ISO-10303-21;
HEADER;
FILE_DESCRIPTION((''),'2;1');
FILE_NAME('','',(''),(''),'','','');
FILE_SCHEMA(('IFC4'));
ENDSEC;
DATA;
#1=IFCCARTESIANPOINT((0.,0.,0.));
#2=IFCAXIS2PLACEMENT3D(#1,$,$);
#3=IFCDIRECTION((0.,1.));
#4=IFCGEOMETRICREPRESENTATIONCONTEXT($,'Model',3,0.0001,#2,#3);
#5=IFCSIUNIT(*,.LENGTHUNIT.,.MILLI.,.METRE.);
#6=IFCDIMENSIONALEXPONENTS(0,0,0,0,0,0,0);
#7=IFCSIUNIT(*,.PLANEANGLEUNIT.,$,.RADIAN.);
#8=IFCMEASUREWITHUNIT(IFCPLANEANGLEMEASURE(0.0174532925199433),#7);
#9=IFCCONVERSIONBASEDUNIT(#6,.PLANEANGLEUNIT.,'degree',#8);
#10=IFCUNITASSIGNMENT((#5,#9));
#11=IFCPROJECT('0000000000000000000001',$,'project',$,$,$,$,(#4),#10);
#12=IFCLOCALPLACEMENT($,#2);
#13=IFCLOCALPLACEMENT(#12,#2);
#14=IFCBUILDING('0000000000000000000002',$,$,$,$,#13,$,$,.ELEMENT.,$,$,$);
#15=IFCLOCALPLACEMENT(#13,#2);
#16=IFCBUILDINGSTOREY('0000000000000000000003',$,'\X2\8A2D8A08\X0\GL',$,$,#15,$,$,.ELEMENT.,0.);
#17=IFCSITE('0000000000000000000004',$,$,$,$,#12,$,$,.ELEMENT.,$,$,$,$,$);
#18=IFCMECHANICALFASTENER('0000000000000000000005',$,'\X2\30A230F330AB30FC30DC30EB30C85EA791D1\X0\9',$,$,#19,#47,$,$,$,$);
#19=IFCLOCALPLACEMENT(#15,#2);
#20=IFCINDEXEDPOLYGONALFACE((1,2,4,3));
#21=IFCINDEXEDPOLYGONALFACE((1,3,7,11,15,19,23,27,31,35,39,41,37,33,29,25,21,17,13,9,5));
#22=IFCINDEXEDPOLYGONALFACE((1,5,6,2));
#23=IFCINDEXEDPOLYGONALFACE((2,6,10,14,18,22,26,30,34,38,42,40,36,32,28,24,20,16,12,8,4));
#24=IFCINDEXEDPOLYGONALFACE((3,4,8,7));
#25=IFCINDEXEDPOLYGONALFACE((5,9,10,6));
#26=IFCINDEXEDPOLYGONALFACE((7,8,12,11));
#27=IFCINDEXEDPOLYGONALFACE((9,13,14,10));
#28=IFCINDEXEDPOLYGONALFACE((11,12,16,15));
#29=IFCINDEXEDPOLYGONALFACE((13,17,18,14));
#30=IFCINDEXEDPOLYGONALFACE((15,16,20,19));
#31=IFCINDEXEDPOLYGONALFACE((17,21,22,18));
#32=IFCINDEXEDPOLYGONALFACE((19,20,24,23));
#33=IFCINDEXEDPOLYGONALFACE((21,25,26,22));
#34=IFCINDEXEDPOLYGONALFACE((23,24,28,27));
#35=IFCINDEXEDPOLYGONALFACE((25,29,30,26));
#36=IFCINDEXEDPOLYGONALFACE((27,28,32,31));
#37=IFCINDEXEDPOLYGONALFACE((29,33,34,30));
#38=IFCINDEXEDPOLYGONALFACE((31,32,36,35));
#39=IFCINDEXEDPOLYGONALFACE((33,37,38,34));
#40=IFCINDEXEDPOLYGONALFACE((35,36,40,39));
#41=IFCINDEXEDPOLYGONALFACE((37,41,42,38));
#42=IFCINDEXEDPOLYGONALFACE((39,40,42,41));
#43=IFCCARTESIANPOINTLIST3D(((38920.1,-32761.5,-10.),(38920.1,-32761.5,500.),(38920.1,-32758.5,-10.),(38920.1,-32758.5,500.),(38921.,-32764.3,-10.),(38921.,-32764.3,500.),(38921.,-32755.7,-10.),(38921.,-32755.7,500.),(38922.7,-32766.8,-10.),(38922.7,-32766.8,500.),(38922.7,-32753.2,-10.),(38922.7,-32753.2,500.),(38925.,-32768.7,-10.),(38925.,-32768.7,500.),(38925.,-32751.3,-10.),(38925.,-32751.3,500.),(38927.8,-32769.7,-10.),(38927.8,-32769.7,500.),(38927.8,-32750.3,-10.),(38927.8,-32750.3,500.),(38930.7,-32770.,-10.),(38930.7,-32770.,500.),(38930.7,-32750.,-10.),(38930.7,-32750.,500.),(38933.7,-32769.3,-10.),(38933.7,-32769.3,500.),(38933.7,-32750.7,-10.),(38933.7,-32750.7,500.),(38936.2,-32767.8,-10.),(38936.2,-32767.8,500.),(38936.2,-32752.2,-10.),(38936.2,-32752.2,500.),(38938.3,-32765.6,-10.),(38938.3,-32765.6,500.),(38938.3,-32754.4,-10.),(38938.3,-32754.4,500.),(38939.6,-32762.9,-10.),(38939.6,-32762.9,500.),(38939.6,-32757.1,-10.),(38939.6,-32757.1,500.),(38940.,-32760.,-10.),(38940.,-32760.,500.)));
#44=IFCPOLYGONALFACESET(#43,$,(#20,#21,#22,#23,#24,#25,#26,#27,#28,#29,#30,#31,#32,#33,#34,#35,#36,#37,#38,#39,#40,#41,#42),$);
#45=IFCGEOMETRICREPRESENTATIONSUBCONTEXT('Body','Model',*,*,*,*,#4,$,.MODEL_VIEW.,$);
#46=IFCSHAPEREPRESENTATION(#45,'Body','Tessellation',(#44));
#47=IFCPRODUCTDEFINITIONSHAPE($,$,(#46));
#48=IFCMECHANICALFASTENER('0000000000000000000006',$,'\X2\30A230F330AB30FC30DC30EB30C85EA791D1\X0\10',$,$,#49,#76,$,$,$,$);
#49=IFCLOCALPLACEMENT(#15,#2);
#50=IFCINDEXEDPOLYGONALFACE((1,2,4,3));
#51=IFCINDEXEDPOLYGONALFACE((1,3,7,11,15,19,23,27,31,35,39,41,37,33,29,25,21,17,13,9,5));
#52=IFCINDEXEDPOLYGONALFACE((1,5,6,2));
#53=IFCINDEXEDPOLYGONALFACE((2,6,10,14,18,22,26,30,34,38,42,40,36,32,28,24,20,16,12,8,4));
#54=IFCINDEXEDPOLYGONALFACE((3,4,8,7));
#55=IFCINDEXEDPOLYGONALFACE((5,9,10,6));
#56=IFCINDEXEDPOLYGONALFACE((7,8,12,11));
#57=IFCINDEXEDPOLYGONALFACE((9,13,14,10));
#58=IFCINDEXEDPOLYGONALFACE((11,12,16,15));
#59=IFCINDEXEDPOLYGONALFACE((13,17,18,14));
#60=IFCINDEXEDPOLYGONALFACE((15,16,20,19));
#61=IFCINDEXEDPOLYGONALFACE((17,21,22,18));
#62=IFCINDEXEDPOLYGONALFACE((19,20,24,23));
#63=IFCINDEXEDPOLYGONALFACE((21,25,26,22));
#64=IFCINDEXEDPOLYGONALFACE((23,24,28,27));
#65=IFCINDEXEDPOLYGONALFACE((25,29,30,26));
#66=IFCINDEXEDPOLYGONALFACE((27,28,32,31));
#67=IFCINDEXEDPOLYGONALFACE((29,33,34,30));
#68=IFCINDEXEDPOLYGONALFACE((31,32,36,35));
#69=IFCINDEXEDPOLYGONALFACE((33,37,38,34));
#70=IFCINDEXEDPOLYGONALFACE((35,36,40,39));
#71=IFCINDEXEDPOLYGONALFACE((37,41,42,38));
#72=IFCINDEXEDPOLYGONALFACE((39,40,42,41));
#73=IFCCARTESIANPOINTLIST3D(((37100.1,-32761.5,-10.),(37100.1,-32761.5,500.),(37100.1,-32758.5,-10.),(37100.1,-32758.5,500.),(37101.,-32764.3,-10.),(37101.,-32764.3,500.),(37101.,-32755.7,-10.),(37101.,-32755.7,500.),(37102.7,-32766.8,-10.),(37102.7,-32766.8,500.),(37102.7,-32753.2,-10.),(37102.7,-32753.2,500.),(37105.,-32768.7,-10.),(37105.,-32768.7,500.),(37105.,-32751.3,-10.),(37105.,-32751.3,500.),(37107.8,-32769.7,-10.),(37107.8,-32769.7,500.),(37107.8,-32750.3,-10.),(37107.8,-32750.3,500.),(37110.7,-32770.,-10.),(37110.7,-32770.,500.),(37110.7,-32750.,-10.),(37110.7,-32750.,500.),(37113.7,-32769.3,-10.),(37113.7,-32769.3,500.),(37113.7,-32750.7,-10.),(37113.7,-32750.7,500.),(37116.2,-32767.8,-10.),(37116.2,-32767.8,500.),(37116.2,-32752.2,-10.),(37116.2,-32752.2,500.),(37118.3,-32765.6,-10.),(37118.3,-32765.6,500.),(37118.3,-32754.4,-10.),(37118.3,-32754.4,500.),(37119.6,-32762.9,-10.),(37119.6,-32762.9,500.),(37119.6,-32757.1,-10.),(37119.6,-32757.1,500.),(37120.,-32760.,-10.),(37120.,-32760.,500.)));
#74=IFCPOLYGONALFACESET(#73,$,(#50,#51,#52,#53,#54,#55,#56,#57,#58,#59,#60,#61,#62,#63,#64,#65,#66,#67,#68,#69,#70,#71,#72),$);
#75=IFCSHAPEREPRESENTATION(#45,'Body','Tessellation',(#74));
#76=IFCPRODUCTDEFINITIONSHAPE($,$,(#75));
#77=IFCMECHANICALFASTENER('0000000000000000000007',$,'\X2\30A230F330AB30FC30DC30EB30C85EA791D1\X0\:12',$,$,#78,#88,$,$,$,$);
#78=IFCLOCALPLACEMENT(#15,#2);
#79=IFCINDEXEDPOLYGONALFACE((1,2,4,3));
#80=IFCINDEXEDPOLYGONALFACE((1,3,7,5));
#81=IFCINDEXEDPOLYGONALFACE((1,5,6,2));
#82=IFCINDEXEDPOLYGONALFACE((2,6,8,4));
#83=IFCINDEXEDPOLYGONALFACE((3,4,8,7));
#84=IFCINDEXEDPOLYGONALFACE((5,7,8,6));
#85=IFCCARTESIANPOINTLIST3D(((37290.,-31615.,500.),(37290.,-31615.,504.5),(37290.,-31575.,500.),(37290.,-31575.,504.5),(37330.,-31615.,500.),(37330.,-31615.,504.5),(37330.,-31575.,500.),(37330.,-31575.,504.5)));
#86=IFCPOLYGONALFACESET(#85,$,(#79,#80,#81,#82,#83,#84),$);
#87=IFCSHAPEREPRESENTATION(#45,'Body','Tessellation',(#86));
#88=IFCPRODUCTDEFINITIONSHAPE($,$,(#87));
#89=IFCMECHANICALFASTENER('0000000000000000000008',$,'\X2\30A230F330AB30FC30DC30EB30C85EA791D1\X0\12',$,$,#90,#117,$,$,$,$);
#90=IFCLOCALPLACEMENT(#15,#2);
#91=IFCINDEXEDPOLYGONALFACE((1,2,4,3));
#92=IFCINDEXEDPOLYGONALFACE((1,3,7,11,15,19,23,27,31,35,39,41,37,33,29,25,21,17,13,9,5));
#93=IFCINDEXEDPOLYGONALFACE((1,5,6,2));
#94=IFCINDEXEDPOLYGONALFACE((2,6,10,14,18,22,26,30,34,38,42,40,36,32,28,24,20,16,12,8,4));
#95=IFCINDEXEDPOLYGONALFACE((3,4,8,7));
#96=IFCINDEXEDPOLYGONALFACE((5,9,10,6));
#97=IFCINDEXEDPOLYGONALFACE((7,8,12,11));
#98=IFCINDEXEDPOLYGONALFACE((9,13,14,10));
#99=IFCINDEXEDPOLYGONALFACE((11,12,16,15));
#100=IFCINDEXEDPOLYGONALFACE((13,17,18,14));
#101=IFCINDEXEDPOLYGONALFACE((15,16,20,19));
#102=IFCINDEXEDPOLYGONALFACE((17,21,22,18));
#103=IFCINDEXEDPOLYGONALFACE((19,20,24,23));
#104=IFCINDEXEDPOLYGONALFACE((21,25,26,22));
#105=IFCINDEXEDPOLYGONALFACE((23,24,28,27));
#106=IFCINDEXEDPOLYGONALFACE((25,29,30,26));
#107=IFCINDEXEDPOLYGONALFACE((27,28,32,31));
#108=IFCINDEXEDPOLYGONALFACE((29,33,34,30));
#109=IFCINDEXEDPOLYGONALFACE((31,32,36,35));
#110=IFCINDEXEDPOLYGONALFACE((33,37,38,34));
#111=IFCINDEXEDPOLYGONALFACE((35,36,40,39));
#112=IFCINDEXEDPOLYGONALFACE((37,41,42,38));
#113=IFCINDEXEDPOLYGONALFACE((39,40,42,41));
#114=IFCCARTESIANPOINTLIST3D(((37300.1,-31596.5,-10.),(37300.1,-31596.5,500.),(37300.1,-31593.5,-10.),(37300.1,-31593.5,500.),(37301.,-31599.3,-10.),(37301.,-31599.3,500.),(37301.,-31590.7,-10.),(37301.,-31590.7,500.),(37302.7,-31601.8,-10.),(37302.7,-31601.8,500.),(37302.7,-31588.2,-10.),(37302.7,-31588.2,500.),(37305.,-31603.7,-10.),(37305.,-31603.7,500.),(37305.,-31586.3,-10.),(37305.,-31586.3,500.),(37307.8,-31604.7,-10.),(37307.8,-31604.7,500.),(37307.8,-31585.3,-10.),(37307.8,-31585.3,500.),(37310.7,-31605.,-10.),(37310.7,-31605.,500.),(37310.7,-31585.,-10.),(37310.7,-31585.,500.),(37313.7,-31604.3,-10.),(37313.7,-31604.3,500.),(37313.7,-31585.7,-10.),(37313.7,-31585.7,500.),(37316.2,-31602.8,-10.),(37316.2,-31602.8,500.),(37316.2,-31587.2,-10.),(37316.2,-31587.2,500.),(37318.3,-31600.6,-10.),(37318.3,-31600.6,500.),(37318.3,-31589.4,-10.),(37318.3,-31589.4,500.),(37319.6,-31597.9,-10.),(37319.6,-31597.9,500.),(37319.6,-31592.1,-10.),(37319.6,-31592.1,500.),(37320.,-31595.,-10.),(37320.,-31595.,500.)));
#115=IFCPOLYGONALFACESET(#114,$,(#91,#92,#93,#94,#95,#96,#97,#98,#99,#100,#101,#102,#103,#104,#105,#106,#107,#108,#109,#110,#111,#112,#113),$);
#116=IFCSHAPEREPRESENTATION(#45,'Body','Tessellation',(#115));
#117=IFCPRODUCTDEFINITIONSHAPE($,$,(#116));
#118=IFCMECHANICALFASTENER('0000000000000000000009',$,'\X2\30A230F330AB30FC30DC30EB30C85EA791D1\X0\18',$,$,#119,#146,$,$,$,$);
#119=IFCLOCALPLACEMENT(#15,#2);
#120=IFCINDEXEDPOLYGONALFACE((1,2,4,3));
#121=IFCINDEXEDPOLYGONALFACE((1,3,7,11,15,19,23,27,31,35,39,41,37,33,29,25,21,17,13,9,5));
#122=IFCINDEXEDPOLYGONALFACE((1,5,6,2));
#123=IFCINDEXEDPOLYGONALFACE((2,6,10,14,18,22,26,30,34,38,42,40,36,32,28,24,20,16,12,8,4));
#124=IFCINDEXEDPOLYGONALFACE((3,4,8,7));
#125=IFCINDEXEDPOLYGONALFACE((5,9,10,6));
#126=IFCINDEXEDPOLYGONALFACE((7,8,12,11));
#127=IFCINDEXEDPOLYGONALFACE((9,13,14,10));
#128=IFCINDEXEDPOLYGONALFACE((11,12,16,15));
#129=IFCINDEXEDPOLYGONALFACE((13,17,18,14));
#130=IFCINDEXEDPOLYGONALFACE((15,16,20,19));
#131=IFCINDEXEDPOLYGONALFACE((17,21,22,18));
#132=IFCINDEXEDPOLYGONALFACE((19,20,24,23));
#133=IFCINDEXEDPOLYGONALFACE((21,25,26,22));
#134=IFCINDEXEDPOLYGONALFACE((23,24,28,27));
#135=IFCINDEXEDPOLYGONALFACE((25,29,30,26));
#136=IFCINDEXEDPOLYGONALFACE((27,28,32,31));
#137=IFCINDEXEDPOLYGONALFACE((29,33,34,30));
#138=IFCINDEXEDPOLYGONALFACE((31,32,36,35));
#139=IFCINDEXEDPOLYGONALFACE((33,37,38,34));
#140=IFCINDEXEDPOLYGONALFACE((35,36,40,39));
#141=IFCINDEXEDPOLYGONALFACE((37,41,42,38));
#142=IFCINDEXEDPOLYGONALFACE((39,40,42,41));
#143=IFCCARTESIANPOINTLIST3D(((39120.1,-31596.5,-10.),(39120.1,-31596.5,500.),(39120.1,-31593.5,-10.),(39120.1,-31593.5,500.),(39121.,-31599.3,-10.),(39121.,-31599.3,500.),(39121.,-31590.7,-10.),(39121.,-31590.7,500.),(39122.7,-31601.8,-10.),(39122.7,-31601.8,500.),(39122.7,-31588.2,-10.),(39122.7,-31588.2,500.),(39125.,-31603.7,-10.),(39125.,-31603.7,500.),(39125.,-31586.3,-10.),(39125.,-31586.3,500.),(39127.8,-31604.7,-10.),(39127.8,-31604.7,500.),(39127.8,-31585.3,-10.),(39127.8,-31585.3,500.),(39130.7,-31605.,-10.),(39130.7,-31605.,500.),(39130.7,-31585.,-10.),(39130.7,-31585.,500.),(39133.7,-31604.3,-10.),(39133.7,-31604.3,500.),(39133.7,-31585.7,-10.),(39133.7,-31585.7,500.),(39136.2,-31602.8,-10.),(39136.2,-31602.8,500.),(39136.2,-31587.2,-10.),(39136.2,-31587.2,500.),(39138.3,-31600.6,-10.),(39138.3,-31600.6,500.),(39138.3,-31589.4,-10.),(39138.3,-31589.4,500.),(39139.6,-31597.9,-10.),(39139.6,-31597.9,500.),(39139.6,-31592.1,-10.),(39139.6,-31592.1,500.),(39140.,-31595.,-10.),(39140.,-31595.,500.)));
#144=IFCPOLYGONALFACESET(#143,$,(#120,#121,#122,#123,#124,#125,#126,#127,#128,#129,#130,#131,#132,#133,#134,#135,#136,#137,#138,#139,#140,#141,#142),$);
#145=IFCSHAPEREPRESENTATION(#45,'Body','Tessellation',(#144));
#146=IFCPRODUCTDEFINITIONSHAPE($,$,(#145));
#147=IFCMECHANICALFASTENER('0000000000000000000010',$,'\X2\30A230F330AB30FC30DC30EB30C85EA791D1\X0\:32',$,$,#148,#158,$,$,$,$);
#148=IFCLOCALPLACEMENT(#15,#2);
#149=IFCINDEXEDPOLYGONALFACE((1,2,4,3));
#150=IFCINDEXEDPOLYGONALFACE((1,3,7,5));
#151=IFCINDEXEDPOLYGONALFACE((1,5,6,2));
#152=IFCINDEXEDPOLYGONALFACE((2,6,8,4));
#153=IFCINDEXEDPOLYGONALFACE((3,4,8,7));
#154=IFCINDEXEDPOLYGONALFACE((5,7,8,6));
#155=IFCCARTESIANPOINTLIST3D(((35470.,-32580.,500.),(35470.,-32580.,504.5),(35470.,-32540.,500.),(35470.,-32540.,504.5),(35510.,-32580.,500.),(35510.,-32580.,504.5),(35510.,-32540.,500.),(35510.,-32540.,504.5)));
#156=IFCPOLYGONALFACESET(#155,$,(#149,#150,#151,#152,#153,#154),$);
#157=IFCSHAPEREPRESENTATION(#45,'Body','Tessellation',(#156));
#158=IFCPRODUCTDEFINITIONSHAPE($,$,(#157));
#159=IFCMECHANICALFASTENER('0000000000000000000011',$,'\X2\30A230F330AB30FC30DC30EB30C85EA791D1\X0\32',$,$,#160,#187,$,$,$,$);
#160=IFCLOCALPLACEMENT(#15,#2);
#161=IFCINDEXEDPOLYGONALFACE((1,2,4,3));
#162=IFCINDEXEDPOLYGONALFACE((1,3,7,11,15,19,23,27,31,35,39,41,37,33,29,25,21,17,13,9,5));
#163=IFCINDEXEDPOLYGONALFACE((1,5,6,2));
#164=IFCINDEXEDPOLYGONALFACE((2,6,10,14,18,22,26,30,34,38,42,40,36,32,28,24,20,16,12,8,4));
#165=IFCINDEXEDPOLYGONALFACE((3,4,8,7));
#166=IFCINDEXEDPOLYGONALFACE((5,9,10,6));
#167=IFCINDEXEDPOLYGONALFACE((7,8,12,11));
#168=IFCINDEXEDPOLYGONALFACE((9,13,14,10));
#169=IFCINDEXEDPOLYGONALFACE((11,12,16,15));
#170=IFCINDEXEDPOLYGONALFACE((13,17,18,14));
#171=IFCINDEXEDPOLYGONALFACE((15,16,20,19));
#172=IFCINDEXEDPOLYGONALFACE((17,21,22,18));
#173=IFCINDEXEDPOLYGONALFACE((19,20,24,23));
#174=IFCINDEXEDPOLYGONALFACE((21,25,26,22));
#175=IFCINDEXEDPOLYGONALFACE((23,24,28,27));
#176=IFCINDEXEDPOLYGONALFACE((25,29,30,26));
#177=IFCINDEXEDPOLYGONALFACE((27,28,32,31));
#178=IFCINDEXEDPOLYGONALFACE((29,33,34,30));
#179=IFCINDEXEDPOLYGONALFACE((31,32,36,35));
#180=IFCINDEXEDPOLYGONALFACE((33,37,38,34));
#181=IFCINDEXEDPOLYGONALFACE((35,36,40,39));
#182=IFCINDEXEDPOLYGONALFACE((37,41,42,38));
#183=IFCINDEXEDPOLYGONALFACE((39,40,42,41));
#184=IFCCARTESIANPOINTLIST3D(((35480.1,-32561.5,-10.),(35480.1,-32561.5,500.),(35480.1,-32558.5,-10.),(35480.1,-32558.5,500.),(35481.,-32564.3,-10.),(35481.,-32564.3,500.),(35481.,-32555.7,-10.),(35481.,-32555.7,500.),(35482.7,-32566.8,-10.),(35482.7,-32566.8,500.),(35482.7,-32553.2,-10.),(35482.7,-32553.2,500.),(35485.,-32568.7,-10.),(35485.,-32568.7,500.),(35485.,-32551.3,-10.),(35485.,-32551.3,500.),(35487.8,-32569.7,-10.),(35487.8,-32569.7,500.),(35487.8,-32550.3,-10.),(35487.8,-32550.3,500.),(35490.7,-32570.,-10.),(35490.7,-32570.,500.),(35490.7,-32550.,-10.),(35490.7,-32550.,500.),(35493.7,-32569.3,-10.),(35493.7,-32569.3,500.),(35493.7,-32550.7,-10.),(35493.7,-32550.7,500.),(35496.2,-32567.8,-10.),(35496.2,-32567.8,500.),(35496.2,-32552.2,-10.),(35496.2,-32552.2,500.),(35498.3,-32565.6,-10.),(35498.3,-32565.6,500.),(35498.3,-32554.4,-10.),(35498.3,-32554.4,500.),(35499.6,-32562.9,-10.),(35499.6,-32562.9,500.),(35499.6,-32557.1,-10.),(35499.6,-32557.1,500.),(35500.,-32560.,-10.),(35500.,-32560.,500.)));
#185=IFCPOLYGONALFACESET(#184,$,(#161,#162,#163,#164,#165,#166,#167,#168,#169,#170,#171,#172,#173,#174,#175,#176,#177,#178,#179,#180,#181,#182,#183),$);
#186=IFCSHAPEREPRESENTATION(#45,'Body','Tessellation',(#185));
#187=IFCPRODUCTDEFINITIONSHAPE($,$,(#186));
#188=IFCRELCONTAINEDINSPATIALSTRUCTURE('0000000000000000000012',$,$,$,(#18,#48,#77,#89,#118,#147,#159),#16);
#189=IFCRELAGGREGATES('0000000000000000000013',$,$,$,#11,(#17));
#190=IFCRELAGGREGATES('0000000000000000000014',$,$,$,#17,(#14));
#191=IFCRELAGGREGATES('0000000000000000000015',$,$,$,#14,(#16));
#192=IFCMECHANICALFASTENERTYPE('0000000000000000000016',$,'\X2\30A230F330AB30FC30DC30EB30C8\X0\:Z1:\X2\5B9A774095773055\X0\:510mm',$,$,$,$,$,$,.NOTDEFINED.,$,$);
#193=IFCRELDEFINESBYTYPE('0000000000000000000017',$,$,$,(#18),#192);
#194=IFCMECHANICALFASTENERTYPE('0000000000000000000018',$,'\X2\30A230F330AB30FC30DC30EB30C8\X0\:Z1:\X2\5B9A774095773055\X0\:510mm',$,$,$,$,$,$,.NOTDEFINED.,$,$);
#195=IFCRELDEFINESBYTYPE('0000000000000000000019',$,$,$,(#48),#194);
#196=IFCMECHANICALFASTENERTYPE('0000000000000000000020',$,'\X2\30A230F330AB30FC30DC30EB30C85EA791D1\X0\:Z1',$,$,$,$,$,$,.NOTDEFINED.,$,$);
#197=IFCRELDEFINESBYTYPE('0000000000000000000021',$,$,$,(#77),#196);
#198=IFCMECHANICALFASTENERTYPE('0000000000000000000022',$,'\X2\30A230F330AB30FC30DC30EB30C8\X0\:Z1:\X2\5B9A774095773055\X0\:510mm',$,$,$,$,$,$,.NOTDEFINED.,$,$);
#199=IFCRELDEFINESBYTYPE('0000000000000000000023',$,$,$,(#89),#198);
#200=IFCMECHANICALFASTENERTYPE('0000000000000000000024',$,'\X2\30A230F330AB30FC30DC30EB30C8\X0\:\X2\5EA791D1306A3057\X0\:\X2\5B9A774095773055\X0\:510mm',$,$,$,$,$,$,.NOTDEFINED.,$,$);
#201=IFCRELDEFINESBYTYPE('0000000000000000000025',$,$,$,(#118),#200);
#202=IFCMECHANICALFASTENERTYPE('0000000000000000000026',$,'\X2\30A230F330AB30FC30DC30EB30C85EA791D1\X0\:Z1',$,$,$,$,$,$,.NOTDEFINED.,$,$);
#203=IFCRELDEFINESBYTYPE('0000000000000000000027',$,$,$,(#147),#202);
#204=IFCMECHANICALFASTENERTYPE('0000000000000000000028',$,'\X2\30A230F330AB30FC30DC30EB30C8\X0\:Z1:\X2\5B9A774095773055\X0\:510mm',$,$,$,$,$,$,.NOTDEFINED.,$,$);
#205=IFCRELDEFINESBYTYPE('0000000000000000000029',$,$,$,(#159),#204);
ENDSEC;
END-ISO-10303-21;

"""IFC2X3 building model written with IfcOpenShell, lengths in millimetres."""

from ifc_helpers import new_model, entity, si_unit, converted_unit, direction, frame, origin, origin_with_axes, origin_2d, place, context, subcontext, project, spatial, rectangle, circle, extrude, type_object, element, save


model = new_model("IFC2X3")

# Units and contexts
model_context = context("Model", 3, precision=0.0001, world=origin(), true_north=direction((0.0, 1.0)))
body_context = subcontext(model_context, "Body", "Model", "MODEL_VIEW")
ifc_project = project(units=[si_unit("LENGTHUNIT", "METRE", prefix="MILLI"), converted_unit("PLANEANGLEUNIT", "degree", entity("IfcPlaneAngleMeasure", 0.0174532925199433), si_unit("PLANEANGLEUNIT", "RADIAN"), dimensions=[0, 0, 0, 0, 0, 0, 0])], contexts=[model_context])

# Site, building, storey
site_placement = place(None, origin())
site = spatial("IfcSite", under=ifc_project, at=site_placement, CompositionType="ELEMENT")
building_placement = place(site_placement, origin())
building = spatial("IfcBuilding", under=site, at=building_placement, CompositionType="ELEMENT")
storey_placement = place(building_placement, origin())
storey = spatial("IfcBuildingStorey", under=building, at=storey_placement, Name="設計GL", CompositionType="ELEMENT", Elevation=0.0)

# Mechanical fasteners
mechanical_fastener_type_1 = type_object("IfcMechanicalFastenerType", Name="アンカーボルト:Z1:定着長さ:510mm")
mechanical_fastener_1_placement = place(storey_placement, frame((38930.0, -32760.0, -10.0)))
element("IfcMechanicalFastener", 1, at=mechanical_fastener_1_placement, inside=storey, type_object=mechanical_fastener_type_1, Name="アンカーボルト座金9", context=body_context, shape_type="SweptSolid", body=[
    extrude(circle(Radius=10.0, at=origin_2d()), origin_with_axes(), (0.0, 0.0, 1.0), 510.0),
])
mechanical_fastener_type_2 = type_object("IfcMechanicalFastenerType", Name="アンカーボルト:Z1:定着長さ:510mm")
mechanical_fastener_2_placement = place(storey_placement, frame((37110.0, -32760.0, -10.0)))
element("IfcMechanicalFastener", 2, at=mechanical_fastener_2_placement, inside=storey, type_object=mechanical_fastener_type_2, Name="アンカーボルト座金10", context=body_context, shape_type="SweptSolid", body=[
    extrude(circle(Radius=10.0, at=origin_2d()), origin_with_axes(), (0.0, 0.0, 1.0), 510.0),
])
mechanical_fastener_type_3 = type_object("IfcMechanicalFastenerType", Name="アンカーボルト座金:Z1")
mechanical_fastener_3_placement = place(storey_placement, frame((37310.0, -31595.0, 500.0)))
element("IfcMechanicalFastener", 3, at=mechanical_fastener_3_placement, inside=storey, type_object=mechanical_fastener_type_3, Name="アンカーボルト座金:12", context=body_context, shape_type="SweptSolid", body=[
    extrude(rectangle(XDim=40.0, YDim=40.0, at=origin_2d()), origin_with_axes(), (0.0, 0.0, 1.0), 4.5),
])
mechanical_fastener_type_4 = type_object("IfcMechanicalFastenerType", Name="アンカーボルト:Z1:定着長さ:510mm")
mechanical_fastener_4_placement = place(storey_placement, frame((37310.0, -31595.0, -10.0)))
element("IfcMechanicalFastener", 4, at=mechanical_fastener_4_placement, inside=storey, type_object=mechanical_fastener_type_4, Name="アンカーボルト座金12", context=body_context, shape_type="SweptSolid", body=[
    extrude(circle(Radius=10.0, at=origin_2d()), origin_with_axes(), (0.0, 0.0, 1.0), 510.0),
])
mechanical_fastener_type_5 = type_object("IfcMechanicalFastenerType", Name="アンカーボルト:座金なし:定着長さ:510mm")
mechanical_fastener_5_placement = place(storey_placement, frame((39130.0, -31595.0, -10.0)))
element("IfcMechanicalFastener", 5, at=mechanical_fastener_5_placement, inside=storey, type_object=mechanical_fastener_type_5, Name="アンカーボルト座金18", context=body_context, shape_type="SweptSolid", body=[
    extrude(circle(Radius=10.0, at=origin_2d()), origin_with_axes(), (0.0, 0.0, 1.0), 510.0),
])
mechanical_fastener_type_6 = type_object("IfcMechanicalFastenerType", Name="アンカーボルト座金:Z1")
mechanical_fastener_6_placement = place(storey_placement, frame((35490.0, -32560.0, 500.0)))
element("IfcMechanicalFastener", 6, at=mechanical_fastener_6_placement, inside=storey, type_object=mechanical_fastener_type_6, Name="アンカーボルト座金:32", context=body_context, shape_type="SweptSolid", body=[
    extrude(rectangle(XDim=40.0, YDim=40.0, at=origin_2d()), origin_with_axes(), (0.0, 0.0, 1.0), 4.5),
])
mechanical_fastener_type_7 = type_object("IfcMechanicalFastenerType", Name="アンカーボルト:Z1:定着長さ:510mm")
mechanical_fastener_7_placement = place(storey_placement, frame((35490.0, -32560.0, -10.0)))
element("IfcMechanicalFastener", 7, at=mechanical_fastener_7_placement, inside=storey, type_object=mechanical_fastener_type_7, Name="アンカーボルト座金32", context=body_context, shape_type="SweptSolid", body=[
    extrude(circle(Radius=10.0, at=origin_2d()), origin_with_axes(), (0.0, 0.0, 1.0), 510.0),
])

save(model, "model.ifc")
